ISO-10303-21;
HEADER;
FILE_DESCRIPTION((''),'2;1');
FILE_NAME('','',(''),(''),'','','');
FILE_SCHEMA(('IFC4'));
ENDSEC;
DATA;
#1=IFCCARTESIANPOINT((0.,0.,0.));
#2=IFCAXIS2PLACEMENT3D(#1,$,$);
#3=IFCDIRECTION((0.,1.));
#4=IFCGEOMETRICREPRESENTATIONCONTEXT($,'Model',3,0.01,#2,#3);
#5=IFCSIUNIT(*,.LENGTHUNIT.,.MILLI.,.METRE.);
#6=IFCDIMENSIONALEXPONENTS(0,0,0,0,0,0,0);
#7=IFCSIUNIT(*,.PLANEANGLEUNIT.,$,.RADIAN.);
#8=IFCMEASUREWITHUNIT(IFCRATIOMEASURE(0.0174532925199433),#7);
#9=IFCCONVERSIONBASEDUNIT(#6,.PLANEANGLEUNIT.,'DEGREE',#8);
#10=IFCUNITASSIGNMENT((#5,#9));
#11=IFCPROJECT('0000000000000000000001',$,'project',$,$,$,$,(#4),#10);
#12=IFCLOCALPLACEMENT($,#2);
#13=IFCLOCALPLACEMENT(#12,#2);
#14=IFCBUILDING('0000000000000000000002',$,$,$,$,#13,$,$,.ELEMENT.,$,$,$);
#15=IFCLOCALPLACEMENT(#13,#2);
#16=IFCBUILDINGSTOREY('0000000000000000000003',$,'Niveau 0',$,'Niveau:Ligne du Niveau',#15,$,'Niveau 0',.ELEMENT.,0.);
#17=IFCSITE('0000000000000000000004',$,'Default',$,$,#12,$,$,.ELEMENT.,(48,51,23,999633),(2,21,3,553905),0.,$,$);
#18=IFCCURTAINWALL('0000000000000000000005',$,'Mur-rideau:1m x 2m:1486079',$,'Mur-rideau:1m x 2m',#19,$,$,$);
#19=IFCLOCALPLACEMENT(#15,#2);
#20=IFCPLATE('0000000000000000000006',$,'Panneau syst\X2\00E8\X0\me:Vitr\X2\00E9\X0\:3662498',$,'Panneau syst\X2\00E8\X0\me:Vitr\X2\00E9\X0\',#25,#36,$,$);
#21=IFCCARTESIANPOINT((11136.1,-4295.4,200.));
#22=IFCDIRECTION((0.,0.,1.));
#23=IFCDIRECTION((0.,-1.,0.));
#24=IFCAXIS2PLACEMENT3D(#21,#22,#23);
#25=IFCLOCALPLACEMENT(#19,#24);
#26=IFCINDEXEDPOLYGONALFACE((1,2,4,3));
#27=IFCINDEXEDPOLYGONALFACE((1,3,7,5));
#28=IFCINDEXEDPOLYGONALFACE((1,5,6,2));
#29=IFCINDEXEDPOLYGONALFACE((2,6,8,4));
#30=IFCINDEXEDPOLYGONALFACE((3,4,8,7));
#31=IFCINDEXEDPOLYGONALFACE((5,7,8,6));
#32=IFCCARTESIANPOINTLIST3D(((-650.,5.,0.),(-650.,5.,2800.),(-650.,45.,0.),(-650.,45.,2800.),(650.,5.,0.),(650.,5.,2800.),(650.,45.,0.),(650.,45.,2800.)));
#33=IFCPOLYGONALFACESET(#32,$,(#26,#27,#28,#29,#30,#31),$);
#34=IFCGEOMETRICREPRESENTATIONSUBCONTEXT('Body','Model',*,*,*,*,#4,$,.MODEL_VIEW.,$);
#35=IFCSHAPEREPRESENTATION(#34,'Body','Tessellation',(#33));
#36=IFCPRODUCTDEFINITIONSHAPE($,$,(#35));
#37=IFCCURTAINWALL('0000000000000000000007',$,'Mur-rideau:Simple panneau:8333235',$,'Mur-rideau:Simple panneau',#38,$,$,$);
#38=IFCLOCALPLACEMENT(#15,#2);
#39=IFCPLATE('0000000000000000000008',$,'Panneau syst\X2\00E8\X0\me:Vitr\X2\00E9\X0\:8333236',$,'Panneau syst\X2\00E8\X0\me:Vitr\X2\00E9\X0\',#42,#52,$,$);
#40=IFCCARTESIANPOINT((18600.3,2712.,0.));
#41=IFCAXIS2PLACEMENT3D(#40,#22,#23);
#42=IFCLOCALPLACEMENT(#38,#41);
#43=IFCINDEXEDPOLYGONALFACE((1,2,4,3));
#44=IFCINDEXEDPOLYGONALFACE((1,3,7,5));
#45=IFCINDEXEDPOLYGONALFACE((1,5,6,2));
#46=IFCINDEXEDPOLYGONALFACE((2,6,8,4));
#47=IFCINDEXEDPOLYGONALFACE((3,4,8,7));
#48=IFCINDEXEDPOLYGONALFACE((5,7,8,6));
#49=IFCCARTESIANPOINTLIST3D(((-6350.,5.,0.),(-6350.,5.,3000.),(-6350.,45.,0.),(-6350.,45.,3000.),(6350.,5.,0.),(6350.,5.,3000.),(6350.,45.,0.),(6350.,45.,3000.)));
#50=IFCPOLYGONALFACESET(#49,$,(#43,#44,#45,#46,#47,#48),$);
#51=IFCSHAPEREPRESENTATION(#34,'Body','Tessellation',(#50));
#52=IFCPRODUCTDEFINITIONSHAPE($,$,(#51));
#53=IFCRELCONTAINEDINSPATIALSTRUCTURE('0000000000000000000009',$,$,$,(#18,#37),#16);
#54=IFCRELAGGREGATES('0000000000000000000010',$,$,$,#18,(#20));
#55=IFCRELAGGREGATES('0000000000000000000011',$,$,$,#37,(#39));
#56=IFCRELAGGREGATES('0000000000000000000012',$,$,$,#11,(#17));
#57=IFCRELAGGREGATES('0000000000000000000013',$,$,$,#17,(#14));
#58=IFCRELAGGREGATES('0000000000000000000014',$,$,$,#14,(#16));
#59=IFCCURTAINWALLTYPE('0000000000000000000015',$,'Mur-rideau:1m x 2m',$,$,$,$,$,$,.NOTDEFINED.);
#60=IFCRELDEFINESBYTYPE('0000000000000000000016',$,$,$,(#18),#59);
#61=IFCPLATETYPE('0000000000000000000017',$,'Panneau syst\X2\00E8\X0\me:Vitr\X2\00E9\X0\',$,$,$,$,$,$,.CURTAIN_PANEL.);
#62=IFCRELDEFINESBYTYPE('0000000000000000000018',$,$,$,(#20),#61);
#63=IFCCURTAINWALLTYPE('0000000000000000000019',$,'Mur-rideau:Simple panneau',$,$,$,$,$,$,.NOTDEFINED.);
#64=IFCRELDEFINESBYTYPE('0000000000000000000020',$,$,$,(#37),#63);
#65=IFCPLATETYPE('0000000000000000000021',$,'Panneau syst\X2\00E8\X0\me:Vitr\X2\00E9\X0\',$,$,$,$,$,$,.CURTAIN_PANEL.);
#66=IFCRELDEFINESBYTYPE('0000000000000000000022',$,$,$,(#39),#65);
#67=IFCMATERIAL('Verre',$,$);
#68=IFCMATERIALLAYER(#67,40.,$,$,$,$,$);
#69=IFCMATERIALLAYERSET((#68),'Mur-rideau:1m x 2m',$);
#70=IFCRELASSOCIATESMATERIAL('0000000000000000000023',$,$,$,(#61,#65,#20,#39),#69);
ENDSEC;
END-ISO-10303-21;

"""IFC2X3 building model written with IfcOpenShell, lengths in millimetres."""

from ifc_helpers import new_model, entity, si_unit, converted_unit, direction, frame, frame_2d, origin, place, context, subcontext, project, spatial, rectangle, extrude, source, transform, mapped, material, layer, layer_set, layer_usage, type_object, type_shapes, element, aggregate, save


model = new_model("IFC2X3")

# Units and contexts
model_context = context("Model", 3, precision=0.01, world=origin(), true_north=direction((0.0, 1.0)))
body_context = subcontext(model_context, "Body", "Model", "MODEL_VIEW")
ifc_project = project(units=[si_unit("LENGTHUNIT", "METRE", prefix="MILLI"), converted_unit("PLANEANGLEUNIT", "DEGREE", entity("IfcRatioMeasure", 0.0174532925199433), si_unit("PLANEANGLEUNIT", "RADIAN"), dimensions=[0, 0, 0, 0, 0, 0, 0])], contexts=[model_context])

# Site, building, storey
site_placement = place(None, origin())
site = spatial("IfcSite", under=ifc_project, at=site_placement, Name="Default", CompositionType="ELEMENT", RefLatitude=(48, 51, 23, 999633), RefLongitude=(2, 21, 3, 553905), RefElevation=0.0)
building_placement = place(site_placement, origin())
building = spatial("IfcBuilding", under=site, at=building_placement, CompositionType="ELEMENT")
storey_placement = place(building_placement, origin())
storey = spatial("IfcBuildingStorey", under=building, at=storey_placement, Name="Niveau 0", ObjectType="Niveau:Ligne du Niveau", LongName="Niveau 0", CompositionType="ELEMENT", Elevation=0.0)

# Curtain wall, plate
curtain_wall_type_1 = type_object("IfcCurtainWallType", Name="Mur-rideau:1m x 2m", PredefinedType="NOTDEFINED")
ifc_material_1 = material(Name="Verre")
ifc_layer_1 = layer(ifc_material_1, 40.0)
ifc_layer_set_1 = layer_set([ifc_layer_1], Name="Mur-rideau:1m x 2m")
curtain_wall_1_placement = place(storey_placement, origin())
curtain_wall_1 = element("IfcCurtainWall", 1, at=curtain_wall_1_placement, inside=storey, type_object=curtain_wall_type_1, Name="Mur-rideau:1m x 2m:1486079", ObjectType="Mur-rideau:1m x 2m")
ifc_layer_usage_1 = layer_usage(ifc_layer_set_1, "AXIS3", "POSITIVE", 0.1)
plate_type_1 = type_object("IfcPlateType", Name="Panneau système:Vitré", PredefinedType="CURTAIN_PANEL", material=ifc_layer_set_1)
shared_shape_1 = source(origin(), body_context, "Body", "SweptSolid", [
    extrude(rectangle(XDim=2800.0, YDim=1300.0, at=frame_2d((0.0, 183.3), x_axis=(1.0, 0.0))), frame((-183.3, 5.0, 1400.0), z_axis=(0.0, 1.0, 0.0), x_axis=(0.0, 0.0, 1.0)), (0.0, 0.0, 1.0), 40.0),
])
type_shapes(plate_type_1, [shared_shape_1])
plate_1_placement = place(curtain_wall_1_placement, frame((11136.1, -4295.4, 200.0), z_axis=(0.0, 0.0, 1.0), x_axis=(0.0, -1.0, 0.0)))
plate_1 = element("IfcPlate", 2, at=plate_1_placement, type_object=plate_type_1, material=ifc_layer_usage_1, Name="Panneau système:Vitré:3662498", ObjectType="Panneau système:Vitré", context=body_context, shape_type="MappedRepresentation", body=[
    mapped(shared_shape_1, transform((0.0, 0.0, 0.0), scale=1.0)),
])
aggregate(curtain_wall_1, [plate_1])

# Curtain wall, plate
curtain_wall_type_2 = type_object("IfcCurtainWallType", Name="Mur-rideau:Simple panneau", PredefinedType="NOTDEFINED")
curtain_wall_2_placement = place(storey_placement, origin())
curtain_wall_2 = element("IfcCurtainWall", 3, at=curtain_wall_2_placement, inside=storey, type_object=curtain_wall_type_2, Name="Mur-rideau:Simple panneau:8333235", ObjectType="Mur-rideau:Simple panneau")
ifc_layer_usage_2 = layer_usage(ifc_layer_set_1, "AXIS3", "POSITIVE", 0.1)
plate_type_2 = type_object("IfcPlateType", Name="Panneau système:Vitré", PredefinedType="CURTAIN_PANEL", material=ifc_layer_set_1)
shared_shape_2 = source(origin(), body_context, "Body", "SweptSolid", [
    extrude(rectangle(XDim=40.0, YDim=12700.0, at=frame_2d((0.0, 0.0), x_axis=(1.0, 0.0))), frame((0.0, 25.0, 0.0), z_axis=(0.0, 0.0, 1.0), x_axis=(0.0, 1.0, 0.0)), (0.0, 0.0, 1.0), 3000.0),
])
type_shapes(plate_type_2, [shared_shape_2])
plate_2_placement = place(curtain_wall_2_placement, frame((18600.3, 2712.0, 0.0), z_axis=(0.0, 0.0, 1.0), x_axis=(0.0, -1.0, 0.0)))
plate_2 = element("IfcPlate", 4, at=plate_2_placement, type_object=plate_type_2, material=ifc_layer_usage_2, Name="Panneau système:Vitré:8333236", ObjectType="Panneau système:Vitré", context=body_context, shape_type="MappedRepresentation", body=[
    mapped(shared_shape_2, transform((0.0, 0.0, 0.0), scale=1.0)),
])
aggregate(curtain_wall_2, [plate_2])

save(model, "model.ifc")
